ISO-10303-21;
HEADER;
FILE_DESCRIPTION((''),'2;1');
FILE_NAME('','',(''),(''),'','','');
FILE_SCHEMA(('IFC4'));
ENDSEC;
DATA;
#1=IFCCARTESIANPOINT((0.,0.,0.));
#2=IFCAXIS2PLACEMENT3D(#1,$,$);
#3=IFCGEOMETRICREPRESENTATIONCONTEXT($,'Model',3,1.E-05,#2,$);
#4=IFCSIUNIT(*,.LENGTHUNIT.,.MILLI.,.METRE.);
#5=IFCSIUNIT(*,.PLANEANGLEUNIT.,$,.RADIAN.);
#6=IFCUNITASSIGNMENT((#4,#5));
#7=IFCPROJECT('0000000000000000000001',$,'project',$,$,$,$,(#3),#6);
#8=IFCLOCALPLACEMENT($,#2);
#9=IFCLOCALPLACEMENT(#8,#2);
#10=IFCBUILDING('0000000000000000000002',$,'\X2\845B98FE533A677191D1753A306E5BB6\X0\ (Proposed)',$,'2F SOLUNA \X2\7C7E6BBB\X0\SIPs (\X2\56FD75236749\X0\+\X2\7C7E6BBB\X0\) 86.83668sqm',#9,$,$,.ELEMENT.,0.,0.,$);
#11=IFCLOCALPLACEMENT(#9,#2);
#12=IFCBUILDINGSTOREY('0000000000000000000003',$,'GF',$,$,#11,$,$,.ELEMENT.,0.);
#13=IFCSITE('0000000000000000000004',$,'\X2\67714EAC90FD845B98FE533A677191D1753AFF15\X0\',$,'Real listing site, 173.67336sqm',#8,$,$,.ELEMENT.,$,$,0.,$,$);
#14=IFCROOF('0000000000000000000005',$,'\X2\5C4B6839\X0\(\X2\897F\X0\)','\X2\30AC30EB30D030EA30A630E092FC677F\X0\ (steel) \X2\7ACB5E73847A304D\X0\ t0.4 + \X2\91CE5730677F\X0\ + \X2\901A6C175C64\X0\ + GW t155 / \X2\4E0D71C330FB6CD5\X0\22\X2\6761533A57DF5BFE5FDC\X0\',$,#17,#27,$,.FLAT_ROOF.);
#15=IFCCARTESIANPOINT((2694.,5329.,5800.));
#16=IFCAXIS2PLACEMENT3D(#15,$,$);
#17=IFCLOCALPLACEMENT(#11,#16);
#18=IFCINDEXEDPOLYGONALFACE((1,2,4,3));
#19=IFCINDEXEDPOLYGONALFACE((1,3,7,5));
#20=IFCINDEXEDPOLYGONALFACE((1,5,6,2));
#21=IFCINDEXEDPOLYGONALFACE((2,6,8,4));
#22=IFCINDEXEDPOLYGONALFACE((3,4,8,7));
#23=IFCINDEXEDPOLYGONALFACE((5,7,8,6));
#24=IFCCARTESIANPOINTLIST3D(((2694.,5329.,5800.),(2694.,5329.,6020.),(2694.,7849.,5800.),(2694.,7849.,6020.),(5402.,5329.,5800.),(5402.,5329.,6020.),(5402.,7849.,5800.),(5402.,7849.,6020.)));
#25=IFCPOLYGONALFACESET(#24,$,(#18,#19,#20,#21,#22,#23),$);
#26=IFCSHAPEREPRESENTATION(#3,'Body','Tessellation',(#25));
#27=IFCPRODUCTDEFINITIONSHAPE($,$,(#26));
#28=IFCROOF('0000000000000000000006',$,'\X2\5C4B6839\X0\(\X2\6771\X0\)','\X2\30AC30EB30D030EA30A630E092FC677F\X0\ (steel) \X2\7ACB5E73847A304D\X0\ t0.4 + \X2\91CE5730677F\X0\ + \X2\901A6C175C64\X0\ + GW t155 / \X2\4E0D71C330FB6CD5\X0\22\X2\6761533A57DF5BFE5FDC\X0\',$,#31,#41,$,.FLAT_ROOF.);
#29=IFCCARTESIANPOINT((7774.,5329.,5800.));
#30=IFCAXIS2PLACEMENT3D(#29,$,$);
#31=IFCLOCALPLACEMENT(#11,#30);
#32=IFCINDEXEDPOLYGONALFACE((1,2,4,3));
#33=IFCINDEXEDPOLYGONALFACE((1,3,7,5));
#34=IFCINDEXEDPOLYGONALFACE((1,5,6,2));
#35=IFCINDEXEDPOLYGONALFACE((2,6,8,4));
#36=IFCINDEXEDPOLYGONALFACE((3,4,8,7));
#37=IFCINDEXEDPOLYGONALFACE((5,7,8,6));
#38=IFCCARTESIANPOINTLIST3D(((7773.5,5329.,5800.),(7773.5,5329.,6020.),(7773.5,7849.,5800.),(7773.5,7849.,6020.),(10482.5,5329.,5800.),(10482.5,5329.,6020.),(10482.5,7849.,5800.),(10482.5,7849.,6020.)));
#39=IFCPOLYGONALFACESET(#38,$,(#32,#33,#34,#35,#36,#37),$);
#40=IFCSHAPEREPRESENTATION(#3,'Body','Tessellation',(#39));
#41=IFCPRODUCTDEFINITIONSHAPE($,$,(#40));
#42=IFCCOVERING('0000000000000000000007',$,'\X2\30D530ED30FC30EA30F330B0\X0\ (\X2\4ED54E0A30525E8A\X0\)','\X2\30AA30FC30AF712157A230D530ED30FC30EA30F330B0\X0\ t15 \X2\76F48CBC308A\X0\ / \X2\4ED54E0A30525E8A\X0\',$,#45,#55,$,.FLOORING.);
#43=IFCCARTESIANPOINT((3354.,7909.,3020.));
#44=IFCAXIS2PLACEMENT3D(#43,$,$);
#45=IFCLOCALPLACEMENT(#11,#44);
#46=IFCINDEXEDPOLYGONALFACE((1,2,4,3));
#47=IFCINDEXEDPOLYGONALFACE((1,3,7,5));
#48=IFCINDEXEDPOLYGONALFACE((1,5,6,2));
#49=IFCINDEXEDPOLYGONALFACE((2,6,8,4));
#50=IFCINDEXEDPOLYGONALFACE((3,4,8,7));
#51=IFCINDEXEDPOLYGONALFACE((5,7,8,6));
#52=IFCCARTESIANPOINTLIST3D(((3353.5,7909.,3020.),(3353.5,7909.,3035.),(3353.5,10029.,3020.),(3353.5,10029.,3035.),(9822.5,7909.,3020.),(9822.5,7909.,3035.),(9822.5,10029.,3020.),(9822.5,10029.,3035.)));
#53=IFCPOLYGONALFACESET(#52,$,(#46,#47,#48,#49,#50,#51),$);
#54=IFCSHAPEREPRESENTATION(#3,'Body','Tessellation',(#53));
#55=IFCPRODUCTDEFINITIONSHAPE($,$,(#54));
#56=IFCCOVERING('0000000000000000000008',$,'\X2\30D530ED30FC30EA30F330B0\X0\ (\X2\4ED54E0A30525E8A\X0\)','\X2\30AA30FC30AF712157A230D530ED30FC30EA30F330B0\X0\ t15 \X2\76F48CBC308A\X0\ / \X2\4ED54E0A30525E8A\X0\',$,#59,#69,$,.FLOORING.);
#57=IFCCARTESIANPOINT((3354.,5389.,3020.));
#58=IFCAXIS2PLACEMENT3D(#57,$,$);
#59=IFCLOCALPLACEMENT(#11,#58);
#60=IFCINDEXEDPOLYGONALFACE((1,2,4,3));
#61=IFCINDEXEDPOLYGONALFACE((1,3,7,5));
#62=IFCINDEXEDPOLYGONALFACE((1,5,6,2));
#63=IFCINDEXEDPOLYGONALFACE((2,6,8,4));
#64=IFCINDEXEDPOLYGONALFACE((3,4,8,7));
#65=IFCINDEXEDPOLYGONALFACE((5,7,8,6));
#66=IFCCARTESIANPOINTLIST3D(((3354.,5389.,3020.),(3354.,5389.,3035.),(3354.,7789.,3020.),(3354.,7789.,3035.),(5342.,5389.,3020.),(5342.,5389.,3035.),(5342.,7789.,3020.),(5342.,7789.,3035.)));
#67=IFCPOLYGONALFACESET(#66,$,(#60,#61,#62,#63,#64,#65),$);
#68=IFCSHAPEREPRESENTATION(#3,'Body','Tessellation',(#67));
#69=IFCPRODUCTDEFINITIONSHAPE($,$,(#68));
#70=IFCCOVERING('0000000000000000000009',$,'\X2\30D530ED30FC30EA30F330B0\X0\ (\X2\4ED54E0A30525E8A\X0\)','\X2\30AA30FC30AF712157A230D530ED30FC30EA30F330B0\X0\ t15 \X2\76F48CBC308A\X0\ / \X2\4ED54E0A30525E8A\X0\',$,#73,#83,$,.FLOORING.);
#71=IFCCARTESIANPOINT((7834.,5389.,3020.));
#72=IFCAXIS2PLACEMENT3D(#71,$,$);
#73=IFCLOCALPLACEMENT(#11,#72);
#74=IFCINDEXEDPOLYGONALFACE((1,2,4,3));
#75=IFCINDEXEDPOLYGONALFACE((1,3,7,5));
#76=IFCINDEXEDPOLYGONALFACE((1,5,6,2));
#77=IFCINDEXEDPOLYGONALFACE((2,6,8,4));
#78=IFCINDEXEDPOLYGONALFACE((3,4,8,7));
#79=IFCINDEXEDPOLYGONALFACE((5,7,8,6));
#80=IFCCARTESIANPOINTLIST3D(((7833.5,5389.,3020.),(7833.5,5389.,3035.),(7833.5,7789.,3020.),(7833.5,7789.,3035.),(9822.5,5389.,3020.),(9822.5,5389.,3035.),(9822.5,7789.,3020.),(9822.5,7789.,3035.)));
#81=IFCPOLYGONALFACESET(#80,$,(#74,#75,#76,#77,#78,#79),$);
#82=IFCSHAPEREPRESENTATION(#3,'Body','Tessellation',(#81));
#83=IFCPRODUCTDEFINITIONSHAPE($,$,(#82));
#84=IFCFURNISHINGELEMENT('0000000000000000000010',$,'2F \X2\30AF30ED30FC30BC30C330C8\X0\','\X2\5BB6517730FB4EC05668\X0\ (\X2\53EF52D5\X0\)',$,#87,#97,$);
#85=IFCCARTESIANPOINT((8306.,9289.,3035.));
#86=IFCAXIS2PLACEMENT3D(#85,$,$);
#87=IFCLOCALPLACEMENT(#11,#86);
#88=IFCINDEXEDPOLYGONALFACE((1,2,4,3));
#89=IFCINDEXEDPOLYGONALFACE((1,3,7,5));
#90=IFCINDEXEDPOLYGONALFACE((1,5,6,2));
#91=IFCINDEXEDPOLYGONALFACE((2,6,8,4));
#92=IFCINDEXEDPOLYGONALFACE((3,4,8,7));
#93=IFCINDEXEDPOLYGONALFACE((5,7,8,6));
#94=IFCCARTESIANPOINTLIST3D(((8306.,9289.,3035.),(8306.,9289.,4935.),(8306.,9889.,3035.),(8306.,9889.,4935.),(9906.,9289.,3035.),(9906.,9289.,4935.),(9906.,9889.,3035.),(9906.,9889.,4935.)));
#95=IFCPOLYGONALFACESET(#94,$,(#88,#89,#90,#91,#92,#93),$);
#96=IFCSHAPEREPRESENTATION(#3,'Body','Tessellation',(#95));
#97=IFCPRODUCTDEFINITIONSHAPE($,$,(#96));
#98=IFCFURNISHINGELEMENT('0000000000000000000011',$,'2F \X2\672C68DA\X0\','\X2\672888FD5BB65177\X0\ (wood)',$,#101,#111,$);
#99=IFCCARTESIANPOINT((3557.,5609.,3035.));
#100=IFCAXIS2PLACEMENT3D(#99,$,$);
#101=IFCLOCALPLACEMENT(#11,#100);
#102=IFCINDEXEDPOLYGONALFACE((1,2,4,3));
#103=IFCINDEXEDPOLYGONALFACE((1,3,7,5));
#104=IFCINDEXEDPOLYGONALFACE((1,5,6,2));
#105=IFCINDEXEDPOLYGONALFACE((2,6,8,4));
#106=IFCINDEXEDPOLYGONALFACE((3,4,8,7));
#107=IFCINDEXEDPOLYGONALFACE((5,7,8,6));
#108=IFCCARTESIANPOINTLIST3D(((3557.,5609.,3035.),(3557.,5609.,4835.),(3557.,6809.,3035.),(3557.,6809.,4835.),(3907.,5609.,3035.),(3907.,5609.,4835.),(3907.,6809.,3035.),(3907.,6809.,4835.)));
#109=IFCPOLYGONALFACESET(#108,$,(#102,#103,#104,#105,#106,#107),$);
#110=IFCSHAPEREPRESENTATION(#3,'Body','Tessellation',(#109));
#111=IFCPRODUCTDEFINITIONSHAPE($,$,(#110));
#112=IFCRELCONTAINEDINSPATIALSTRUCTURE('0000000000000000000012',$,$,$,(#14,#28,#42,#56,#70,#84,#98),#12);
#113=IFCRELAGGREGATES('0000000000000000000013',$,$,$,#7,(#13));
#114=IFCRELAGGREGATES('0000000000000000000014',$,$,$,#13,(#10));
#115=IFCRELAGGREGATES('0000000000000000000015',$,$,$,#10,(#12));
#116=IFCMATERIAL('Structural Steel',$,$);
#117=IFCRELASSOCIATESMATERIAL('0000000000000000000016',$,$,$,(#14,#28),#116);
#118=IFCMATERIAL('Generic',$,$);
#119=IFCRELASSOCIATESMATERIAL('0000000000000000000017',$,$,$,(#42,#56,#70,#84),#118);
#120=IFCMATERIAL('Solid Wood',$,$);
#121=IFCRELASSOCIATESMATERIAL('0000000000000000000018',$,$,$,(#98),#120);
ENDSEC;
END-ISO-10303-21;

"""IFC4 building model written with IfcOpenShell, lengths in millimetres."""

from ifc_helpers import new_model, si_unit, frame, frame_2d, origin, place, context, project, spatial, rectangle, extrude, material, element, save


model = new_model("IFC4")

# Units and contexts
model_context = context("Model", 3, precision=1e-05, world=origin())
ifc_project = project(units=[si_unit("LENGTHUNIT", "METRE", prefix="MILLI"), si_unit("PLANEANGLEUNIT", "RADIAN")], contexts=[model_context])

# Site, building, storey
site_placement = place(None, origin())
site = spatial("IfcSite", under=ifc_project, at=site_placement, Name="東京都葛飾区東金町５", ObjectType="Real listing site, 173.67336sqm", CompositionType="ELEMENT", RefElevation=0.0)
building_placement = place(site_placement, origin())
building = spatial("IfcBuilding", under=site, at=building_placement, Name="葛飾区東金町の家 (Proposed)", ObjectType="2F SOLUNA 籾殻SIPs (国産杉+籾殻) 86.83668sqm", CompositionType="ELEMENT", ElevationOfRefHeight=0.0, ElevationOfTerrain=0.0)
storey_placement = place(building_placement, origin())
storey = spatial("IfcBuildingStorey", under=building, at=storey_placement, Name="GF", CompositionType="ELEMENT", Elevation=0.0)

# Shared definitions
ifc_material_1 = material(Name="Solid Wood")

# Roofs
ifc_material_2 = material(Name="Structural Steel")
roof_1_placement = place(storey_placement, frame((2694.0, 5329.0, 5800.0)))
element("IfcRoof", 1, at=roof_1_placement, inside=storey, material=ifc_material_2, Name="屋根(西)", Description="ガルバリウム鋼板 (steel) 立平葺き t0.4 + 野地板 + 通気層 + GW t155 / 不燃・法22条区域対応", PredefinedType="FLAT_ROOF", context=model_context, shape_type="SweptSolid", body=[
    extrude(rectangle(XDim=2708.0, YDim=2520.0, at=frame_2d((1354.0, 1260.0))), frame((2694.0, 5329.0, 5800.0)), (0.0, 0.0, 1.0), 220.0),
])
roof_2_placement = place(storey_placement, frame((7774.0, 5329.0, 5800.0)))
element("IfcRoof", 2, at=roof_2_placement, inside=storey, material=ifc_material_2, Name="屋根(東)", Description="ガルバリウム鋼板 (steel) 立平葺き t0.4 + 野地板 + 通気層 + GW t155 / 不燃・法22条区域対応", PredefinedType="FLAT_ROOF", context=model_context, shape_type="SweptSolid", body=[
    extrude(rectangle(XDim=2709.0, YDim=2520.0, at=frame_2d((1354.0, 1260.0))), frame((7774.0, 5329.0, 5800.0)), (0.0, 0.0, 1.0), 220.0),
])

# Coverings
ifc_material_3 = material(Name="Generic")
covering_1_placement = place(storey_placement, frame((3354.0, 7909.0, 3020.0)))
element("IfcCovering", 3, at=covering_1_placement, inside=storey, material=ifc_material_3, Name="フローリング (仕上げ床)", Description="オーク無垢フローリング t15 直貼り / 仕上げ床", PredefinedType="FLOORING", context=model_context, shape_type="SweptSolid", body=[
    extrude(rectangle(XDim=6469.0, YDim=2120.0, at=frame_2d((3234.0, 1060.0))), frame((3354.0, 7909.0, 3020.0)), (0.0, 0.0, 1.0), 15.0),
])
covering_2_placement = place(storey_placement, frame((3354.0, 5389.0, 3020.0)))
element("IfcCovering", 4, at=covering_2_placement, inside=storey, material=ifc_material_3, Name="フローリング (仕上げ床)", Description="オーク無垢フローリング t15 直貼り / 仕上げ床", PredefinedType="FLOORING", context=model_context, shape_type="SweptSolid", body=[
    extrude(rectangle(XDim=1988.0, YDim=2400.0, at=frame_2d((994.0, 1200.0))), frame((3354.0, 5389.0, 3020.0)), (0.0, 0.0, 1.0), 15.0),
])
covering_3_placement = place(storey_placement, frame((7834.0, 5389.0, 3020.0)))
element("IfcCovering", 5, at=covering_3_placement, inside=storey, material=ifc_material_3, Name="フローリング (仕上げ床)", Description="オーク無垢フローリング t15 直貼り / 仕上げ床", PredefinedType="FLOORING", context=model_context, shape_type="SweptSolid", body=[
    extrude(rectangle(XDim=1989.0, YDim=2400.0, at=frame_2d((994.0, 1200.0))), frame((7834.0, 5389.0, 3020.0)), (0.0, 0.0, 1.0), 15.0),
])

# Furnishing elements
furnishing_1_placement = place(storey_placement, frame((8306.0, 9289.0, 3035.0)))
element("IfcFurnishingElement", 6, at=furnishing_1_placement, inside=storey, material=ifc_material_3, Name="2F クローゼット", Description="家具・什器 (可動)", context=model_context, shape_type="SweptSolid", body=[
    extrude(rectangle(XDim=1600.0, YDim=600.0, at=frame_2d((800.0, 300.0))), frame((8306.0, 9289.0, 3035.0)), (0.0, 0.0, 1.0), 1900.0),
])
furnishing_2_placement = place(storey_placement, frame((3557.0, 5609.0, 3035.0)))
element("IfcFurnishingElement", 7, at=furnishing_2_placement, inside=storey, material=ifc_material_1, Name="2F 本棚", Description="木製家具 (wood)", context=model_context, shape_type="SweptSolid", body=[
    extrude(rectangle(XDim=350.0, YDim=1200.0, at=frame_2d((175.0, 600.0))), frame((3557.0, 5609.0, 3035.0)), (0.0, 0.0, 1.0), 1800.0),
])

save(model, "model.ifc")
